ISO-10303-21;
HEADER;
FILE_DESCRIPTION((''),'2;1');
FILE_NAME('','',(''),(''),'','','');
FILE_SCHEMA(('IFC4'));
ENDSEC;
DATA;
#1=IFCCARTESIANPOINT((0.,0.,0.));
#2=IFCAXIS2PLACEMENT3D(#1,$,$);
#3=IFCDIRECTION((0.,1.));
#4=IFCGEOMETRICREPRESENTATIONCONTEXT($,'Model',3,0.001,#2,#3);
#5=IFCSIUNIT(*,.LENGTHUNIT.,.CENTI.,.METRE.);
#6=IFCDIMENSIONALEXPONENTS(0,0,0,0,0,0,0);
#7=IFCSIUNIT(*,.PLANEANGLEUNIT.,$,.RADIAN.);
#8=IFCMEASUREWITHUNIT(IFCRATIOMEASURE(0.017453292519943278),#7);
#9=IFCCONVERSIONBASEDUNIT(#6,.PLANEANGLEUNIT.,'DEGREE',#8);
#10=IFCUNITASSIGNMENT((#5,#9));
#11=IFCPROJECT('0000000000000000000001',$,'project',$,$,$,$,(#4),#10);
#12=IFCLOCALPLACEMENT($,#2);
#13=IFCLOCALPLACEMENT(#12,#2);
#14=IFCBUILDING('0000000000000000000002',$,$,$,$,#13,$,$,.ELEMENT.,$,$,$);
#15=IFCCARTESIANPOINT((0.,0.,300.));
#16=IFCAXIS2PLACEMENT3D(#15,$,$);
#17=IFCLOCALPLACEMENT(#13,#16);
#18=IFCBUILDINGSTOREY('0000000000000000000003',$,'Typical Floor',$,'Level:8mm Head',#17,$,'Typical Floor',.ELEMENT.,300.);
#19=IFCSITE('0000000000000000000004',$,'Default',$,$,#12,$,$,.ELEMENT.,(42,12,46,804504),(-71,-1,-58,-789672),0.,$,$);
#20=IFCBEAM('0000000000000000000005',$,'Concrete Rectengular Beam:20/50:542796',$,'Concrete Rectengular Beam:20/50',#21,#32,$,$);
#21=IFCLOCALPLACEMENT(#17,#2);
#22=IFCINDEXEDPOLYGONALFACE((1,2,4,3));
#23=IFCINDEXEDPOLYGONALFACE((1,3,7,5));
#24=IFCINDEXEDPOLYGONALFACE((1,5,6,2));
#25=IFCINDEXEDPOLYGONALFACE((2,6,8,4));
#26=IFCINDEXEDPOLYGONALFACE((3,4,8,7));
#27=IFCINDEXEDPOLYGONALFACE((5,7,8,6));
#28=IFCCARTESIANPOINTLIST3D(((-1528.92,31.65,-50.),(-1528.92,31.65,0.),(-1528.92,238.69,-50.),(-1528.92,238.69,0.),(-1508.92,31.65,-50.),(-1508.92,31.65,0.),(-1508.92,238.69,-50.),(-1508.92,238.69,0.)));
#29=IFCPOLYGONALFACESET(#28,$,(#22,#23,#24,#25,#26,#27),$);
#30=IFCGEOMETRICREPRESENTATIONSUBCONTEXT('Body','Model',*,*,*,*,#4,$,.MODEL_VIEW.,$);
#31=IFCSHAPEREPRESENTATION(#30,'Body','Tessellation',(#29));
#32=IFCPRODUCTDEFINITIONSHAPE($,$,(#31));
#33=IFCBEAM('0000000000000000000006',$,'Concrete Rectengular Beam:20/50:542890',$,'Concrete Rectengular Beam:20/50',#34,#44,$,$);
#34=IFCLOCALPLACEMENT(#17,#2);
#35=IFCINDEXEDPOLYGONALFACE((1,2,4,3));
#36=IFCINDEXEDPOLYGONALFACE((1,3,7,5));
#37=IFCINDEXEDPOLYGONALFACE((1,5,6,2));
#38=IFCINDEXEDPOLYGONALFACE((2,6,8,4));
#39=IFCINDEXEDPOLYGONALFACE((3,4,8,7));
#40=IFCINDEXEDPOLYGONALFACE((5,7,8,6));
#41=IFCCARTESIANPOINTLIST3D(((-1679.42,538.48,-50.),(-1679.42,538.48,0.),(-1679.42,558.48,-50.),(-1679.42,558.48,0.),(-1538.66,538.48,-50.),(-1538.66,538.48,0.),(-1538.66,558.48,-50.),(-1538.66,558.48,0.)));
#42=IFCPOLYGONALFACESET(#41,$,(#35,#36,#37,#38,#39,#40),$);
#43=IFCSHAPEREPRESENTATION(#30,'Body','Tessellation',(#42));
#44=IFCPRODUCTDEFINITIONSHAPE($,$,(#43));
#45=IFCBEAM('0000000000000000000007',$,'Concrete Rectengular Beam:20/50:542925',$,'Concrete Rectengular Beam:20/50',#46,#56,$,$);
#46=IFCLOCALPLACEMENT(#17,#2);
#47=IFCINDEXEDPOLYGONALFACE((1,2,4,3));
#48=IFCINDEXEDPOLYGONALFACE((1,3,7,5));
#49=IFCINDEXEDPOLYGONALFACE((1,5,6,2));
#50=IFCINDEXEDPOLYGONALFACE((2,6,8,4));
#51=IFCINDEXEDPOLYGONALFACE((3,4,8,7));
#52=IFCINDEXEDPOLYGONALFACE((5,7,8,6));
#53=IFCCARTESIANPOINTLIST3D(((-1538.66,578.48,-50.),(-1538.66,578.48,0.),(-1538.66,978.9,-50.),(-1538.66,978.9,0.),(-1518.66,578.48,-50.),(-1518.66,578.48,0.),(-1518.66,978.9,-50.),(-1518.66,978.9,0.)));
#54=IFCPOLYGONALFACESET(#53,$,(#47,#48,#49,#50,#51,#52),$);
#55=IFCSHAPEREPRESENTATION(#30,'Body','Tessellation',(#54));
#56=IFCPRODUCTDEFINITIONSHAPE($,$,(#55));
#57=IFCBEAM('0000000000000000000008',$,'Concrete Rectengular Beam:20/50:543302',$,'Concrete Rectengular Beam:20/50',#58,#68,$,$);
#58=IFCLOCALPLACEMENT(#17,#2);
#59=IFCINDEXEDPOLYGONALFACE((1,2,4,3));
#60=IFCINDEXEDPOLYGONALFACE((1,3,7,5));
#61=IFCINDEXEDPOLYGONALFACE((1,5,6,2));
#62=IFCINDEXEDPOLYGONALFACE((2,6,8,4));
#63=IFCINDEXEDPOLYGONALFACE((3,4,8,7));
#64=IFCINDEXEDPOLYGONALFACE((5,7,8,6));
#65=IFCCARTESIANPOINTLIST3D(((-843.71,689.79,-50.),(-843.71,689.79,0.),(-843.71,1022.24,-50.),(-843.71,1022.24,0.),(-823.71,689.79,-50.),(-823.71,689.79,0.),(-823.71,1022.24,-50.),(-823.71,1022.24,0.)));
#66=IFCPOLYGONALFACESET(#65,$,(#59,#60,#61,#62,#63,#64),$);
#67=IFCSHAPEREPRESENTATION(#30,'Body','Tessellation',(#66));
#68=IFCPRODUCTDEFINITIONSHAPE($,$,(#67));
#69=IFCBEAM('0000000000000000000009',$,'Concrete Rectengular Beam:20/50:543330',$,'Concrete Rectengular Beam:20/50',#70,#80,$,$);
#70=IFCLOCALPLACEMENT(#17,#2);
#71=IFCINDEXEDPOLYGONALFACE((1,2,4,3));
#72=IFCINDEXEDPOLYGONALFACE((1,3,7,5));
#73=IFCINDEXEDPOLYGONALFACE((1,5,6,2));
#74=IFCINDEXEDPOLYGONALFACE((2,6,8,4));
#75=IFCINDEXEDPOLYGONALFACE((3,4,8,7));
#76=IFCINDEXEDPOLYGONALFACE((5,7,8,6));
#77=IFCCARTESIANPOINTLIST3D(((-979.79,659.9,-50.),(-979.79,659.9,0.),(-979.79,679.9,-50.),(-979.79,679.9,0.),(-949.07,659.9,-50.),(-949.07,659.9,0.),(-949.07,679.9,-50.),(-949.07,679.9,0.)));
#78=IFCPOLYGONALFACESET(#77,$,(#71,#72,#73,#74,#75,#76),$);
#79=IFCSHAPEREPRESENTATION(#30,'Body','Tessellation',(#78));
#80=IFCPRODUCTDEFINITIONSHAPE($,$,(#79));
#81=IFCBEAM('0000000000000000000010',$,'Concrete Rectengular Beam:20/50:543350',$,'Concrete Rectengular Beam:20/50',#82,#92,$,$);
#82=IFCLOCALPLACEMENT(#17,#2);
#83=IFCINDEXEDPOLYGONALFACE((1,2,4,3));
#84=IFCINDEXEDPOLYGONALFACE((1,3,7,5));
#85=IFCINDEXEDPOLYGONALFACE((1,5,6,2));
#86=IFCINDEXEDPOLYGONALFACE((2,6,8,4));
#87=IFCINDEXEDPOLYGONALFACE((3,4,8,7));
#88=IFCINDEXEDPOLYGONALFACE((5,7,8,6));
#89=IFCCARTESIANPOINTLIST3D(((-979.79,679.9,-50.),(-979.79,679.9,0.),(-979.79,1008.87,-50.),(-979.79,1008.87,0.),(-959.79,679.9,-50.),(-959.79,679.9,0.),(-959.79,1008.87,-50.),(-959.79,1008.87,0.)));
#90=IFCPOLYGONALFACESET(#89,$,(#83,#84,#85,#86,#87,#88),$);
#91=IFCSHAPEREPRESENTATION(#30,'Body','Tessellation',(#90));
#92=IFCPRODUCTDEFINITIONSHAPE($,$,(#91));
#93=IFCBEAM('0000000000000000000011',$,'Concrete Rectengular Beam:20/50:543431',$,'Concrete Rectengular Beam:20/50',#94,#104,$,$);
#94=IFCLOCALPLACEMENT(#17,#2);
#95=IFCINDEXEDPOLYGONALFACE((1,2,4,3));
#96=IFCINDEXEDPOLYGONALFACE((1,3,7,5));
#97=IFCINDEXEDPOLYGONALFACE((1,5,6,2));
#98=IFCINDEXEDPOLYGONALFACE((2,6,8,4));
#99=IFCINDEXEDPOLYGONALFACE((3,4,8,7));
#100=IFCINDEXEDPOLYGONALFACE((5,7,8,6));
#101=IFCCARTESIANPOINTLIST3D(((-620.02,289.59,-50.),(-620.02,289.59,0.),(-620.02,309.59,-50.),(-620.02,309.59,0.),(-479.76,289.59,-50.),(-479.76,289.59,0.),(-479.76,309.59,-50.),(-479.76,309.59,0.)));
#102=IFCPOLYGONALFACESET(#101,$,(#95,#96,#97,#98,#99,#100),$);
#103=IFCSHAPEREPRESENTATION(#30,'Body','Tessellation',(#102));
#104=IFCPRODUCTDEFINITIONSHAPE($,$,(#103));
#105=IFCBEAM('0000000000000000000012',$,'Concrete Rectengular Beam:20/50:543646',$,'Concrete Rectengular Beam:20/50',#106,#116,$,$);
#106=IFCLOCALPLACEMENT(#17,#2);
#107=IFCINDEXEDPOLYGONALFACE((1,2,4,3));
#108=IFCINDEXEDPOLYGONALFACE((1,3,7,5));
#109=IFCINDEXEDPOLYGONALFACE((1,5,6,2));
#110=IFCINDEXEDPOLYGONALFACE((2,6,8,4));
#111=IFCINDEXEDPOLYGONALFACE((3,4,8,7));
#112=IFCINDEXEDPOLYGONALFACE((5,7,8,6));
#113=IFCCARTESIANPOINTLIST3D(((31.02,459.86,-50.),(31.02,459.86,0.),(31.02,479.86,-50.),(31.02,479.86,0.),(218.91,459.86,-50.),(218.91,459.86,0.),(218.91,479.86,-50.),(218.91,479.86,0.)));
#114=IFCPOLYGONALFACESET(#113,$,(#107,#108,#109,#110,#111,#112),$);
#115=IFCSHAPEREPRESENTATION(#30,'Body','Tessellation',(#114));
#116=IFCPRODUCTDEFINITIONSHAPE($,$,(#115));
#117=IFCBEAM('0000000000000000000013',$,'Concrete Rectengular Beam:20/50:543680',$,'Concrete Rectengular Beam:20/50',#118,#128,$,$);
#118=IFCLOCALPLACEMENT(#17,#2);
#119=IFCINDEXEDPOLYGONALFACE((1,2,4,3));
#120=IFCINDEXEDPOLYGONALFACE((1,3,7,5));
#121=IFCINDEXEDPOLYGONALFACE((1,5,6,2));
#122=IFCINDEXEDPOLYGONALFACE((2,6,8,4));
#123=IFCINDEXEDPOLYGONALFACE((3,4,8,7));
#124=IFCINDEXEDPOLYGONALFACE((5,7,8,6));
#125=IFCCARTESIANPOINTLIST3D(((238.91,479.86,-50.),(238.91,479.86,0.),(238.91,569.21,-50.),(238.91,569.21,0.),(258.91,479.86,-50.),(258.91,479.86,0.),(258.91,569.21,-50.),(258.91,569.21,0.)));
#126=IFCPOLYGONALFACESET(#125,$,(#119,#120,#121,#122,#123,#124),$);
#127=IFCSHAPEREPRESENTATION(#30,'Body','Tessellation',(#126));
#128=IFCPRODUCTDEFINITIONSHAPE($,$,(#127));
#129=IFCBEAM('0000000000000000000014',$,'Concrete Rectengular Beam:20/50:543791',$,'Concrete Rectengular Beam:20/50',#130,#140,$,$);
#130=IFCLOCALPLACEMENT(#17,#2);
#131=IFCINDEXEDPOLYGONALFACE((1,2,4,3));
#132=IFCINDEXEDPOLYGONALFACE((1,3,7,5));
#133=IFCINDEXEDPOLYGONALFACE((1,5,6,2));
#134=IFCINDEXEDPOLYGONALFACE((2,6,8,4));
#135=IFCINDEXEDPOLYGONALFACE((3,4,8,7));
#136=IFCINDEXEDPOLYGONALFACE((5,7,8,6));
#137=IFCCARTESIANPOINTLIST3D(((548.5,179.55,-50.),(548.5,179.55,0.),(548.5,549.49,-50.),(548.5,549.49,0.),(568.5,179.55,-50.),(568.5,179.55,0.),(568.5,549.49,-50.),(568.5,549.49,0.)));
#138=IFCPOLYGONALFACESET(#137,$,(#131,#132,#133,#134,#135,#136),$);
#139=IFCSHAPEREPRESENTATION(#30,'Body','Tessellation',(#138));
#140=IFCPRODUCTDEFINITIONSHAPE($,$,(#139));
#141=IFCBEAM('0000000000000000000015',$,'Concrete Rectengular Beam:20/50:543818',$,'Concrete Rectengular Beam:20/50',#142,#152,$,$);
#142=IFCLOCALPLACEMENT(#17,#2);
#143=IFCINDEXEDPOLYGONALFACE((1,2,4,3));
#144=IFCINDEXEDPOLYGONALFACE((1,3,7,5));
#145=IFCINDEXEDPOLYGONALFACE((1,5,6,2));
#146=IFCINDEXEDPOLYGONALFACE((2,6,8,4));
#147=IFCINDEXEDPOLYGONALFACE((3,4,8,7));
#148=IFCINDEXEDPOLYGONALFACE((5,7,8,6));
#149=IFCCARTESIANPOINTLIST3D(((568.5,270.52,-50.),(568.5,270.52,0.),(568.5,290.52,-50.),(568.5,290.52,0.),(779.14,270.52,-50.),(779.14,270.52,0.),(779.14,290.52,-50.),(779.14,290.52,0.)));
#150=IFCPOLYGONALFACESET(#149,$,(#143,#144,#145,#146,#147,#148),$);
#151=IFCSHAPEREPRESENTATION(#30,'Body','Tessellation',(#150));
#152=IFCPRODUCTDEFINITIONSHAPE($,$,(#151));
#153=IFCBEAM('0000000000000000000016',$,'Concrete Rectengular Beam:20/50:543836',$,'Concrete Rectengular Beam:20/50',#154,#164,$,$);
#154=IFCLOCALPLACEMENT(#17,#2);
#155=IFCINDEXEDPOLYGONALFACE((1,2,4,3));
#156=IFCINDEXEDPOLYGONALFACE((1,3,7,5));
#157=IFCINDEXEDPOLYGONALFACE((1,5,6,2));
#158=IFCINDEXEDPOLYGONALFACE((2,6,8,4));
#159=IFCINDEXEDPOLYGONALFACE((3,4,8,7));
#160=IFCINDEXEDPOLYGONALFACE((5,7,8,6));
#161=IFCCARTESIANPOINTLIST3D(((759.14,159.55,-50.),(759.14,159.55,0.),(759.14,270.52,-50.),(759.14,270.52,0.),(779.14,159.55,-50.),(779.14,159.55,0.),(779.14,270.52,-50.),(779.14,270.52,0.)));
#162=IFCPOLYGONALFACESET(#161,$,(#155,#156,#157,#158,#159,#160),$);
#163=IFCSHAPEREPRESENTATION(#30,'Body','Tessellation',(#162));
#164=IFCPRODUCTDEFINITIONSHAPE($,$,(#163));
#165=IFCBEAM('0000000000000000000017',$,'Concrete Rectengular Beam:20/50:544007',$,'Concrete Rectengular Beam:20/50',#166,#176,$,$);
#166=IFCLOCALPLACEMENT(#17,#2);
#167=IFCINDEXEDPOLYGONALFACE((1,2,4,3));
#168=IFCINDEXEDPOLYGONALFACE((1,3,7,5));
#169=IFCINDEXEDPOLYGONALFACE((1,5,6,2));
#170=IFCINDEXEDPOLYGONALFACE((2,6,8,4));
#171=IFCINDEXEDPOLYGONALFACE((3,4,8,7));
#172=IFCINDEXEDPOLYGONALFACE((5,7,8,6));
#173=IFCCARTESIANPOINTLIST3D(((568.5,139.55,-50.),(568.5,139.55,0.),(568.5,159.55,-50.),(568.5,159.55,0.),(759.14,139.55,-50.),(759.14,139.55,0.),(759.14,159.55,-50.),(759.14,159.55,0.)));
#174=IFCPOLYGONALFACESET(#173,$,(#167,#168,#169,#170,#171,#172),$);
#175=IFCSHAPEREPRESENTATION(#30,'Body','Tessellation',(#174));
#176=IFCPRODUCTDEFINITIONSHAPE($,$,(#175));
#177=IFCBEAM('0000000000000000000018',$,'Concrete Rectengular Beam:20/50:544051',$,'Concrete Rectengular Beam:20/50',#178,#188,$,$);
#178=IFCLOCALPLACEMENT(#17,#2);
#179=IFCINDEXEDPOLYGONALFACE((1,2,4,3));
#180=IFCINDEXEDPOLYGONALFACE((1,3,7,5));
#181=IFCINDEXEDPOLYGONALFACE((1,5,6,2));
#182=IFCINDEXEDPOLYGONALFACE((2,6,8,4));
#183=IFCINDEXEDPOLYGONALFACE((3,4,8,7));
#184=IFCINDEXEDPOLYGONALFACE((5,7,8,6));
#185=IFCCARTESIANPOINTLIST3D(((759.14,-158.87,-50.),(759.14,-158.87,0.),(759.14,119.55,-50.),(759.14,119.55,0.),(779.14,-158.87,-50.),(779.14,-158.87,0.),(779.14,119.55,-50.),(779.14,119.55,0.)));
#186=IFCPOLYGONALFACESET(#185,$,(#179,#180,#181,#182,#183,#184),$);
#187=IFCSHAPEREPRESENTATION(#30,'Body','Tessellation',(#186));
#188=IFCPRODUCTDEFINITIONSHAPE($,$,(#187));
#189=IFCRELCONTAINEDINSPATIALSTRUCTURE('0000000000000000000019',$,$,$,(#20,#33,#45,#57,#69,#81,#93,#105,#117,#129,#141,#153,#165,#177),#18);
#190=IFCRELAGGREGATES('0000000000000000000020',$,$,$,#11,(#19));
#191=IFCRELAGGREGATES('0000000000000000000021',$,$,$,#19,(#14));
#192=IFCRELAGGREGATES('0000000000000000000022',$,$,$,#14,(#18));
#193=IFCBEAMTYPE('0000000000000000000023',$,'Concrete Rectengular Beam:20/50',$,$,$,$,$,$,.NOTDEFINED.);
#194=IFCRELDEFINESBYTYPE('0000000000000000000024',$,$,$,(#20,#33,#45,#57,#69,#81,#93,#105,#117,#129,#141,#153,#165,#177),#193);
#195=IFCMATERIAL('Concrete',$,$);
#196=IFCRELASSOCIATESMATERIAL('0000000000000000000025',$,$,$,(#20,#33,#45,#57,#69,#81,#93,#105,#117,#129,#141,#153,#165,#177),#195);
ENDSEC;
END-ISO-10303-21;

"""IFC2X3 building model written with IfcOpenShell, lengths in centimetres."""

from ifc_helpers import new_model, entity, si_unit, converted_unit, direction, frame, frame_2d, origin, origin_2d_with_axis, place, context, subcontext, project, spatial, rectangle, extrude, material, type_object, element, save


model = new_model("IFC2X3")

# Units and contexts
model_context = context("Model", 3, precision=0.001, world=origin(), true_north=direction((0.0, 1.0)))
body_context = subcontext(model_context, "Body", "Model", "MODEL_VIEW")
ifc_project = project(units=[si_unit("LENGTHUNIT", "METRE", prefix="CENTI"), converted_unit("PLANEANGLEUNIT", "DEGREE", entity("IfcRatioMeasure", 0.017453292519943278), si_unit("PLANEANGLEUNIT", "RADIAN"), dimensions=[0, 0, 0, 0, 0, 0, 0])], contexts=[model_context])

# Site, building, storey
site_placement = place(None, origin())
site = spatial("IfcSite", under=ifc_project, at=site_placement, Name="Default", CompositionType="ELEMENT", RefLatitude=(42, 12, 46, 804504), RefLongitude=(-71, -1, -58, -789672), RefElevation=0.0)
building_placement = place(site_placement, origin())
building = spatial("IfcBuilding", under=site, at=building_placement, CompositionType="ELEMENT")
storey_placement = place(building_placement, frame((0.0, 0.0, 300.0)))
storey = spatial("IfcBuildingStorey", under=building, at=storey_placement, Name="Typical Floor", ObjectType="Level:8mm Head", LongName="Typical Floor", CompositionType="ELEMENT", Elevation=300.0)

# Beams
ifc_material = material(Name="Concrete")
beam_type_1 = type_object("IfcBeamType", Name="Concrete Rectengular Beam:20/50", PredefinedType="NOTDEFINED")
beam_1_placement = place(storey_placement, frame((-1518.92, 11.65, 0.0), z_axis=(0.0, 0.0, 1.0), x_axis=(0.0, 1.0, 0.0)))
element("IfcBeam", 1, at=beam_1_placement, inside=storey, type_object=beam_type_1, material=ifc_material, Name="Concrete Rectengular Beam:20/50:542796", ObjectType="Concrete Rectengular Beam:20/50", context=body_context, shape_type="SweptSolid", body=[
    extrude(rectangle(XDim=50.0, YDim=20.0, at=frame_2d((0.0, 0.0), x_axis=(1.0, 0.0))), frame((20.0, 0.0, -25.0), z_axis=(1.0, 0.0, 0.0), x_axis=(0.0, 0.0, -1.0)), (0.0, 0.0, 1.0), 207.05),
])
beam_2_placement = place(storey_placement, frame((-1528.66, 548.48, 0.0), z_axis=(0.0, 0.0, 1.0), x_axis=(-1.0, 0.0, 0.0)))
element("IfcBeam", 2, at=beam_2_placement, inside=storey, type_object=beam_type_1, material=ifc_material, Name="Concrete Rectengular Beam:20/50:542890", ObjectType="Concrete Rectengular Beam:20/50", context=body_context, shape_type="SweptSolid", body=[
    extrude(rectangle(XDim=50.0, YDim=20.0, at=frame_2d((0.0, 0.0), x_axis=(1.0, 0.0))), frame((10.0, 0.0, -25.0), z_axis=(1.0, 0.0, 0.0), x_axis=(0.0, 0.0, -1.0)), (0.0, 0.0, 1.0), 140.77),
])
beam_3_placement = place(storey_placement, frame((-1528.66, 558.48, 0.0), z_axis=(0.0, 0.0, 1.0), x_axis=(0.0, 1.0, 0.0)))
element("IfcBeam", 3, at=beam_3_placement, inside=storey, type_object=beam_type_1, material=ifc_material, Name="Concrete Rectengular Beam:20/50:542925", ObjectType="Concrete Rectengular Beam:20/50", context=body_context, shape_type="SweptSolid", body=[
    extrude(rectangle(XDim=50.0, YDim=20.0, at=frame_2d((0.0, 0.0), x_axis=(1.0, 0.0))), frame((20.0, 0.0, -25.0), z_axis=(1.0, 0.0, 0.0), x_axis=(0.0, 0.0, -1.0)), (0.0, 0.0, 1.0), 400.41),
])
beam_4_placement = place(storey_placement, frame((-833.71, 1042.24, 0.0), z_axis=(0.0, 0.0, 1.0), x_axis=(0.0, -1.0, 0.0)))
element("IfcBeam", 4, at=beam_4_placement, inside=storey, type_object=beam_type_1, material=ifc_material, Name="Concrete Rectengular Beam:20/50:543302", ObjectType="Concrete Rectengular Beam:20/50", context=body_context, shape_type="SweptSolid", body=[
    extrude(rectangle(XDim=50.0, YDim=20.0, at=frame_2d((0.0, 0.0), x_axis=(1.0, 0.0))), frame((20.0, 0.0, -25.0), z_axis=(1.0, 0.0, 0.0), x_axis=(0.0, 0.0, -1.0)), (0.0, 0.0, 1.0), 332.45),
])
beam_5_placement = place(storey_placement, frame((-939.07, 669.9, 0.0), z_axis=(0.0, 0.0, 1.0), x_axis=(-1.0, 0.0, 0.0)))
element("IfcBeam", 5, at=beam_5_placement, inside=storey, type_object=beam_type_1, material=ifc_material, Name="Concrete Rectengular Beam:20/50:543330", ObjectType="Concrete Rectengular Beam:20/50", context=body_context, shape_type="SweptSolid", body=[
    extrude(rectangle(XDim=50.0, YDim=20.0, at=frame_2d((0.0, 0.0), x_axis=(1.0, 0.0))), frame((10.0, 0.0, -25.0), z_axis=(1.0, 0.0, 0.0), x_axis=(0.0, 0.0, -1.0)), (0.0, 0.0, 1.0), 30.73),
])
beam_6_placement = place(storey_placement, frame((-969.79, 669.9, 0.0), z_axis=(0.0, 0.0, 1.0), x_axis=(0.0, 1.0, 0.0)))
element("IfcBeam", 6, at=beam_6_placement, inside=storey, type_object=beam_type_1, material=ifc_material, Name="Concrete Rectengular Beam:20/50:543350", ObjectType="Concrete Rectengular Beam:20/50", context=body_context, shape_type="SweptSolid", body=[
    extrude(rectangle(XDim=50.0, YDim=20.0, at=frame_2d((0.0, 0.0), x_axis=(1.0, 0.0))), frame((10.0, 0.0, -25.0), z_axis=(1.0, 0.0, 0.0), x_axis=(0.0, 0.0, -1.0)), (0.0, 0.0, 1.0), 328.98),
])
beam_7_placement = place(storey_placement, frame((-469.76, 299.59, 0.0), z_axis=(0.0, 0.0, 1.0), x_axis=(-1.0, 0.0, 0.0)))
element("IfcBeam", 7, at=beam_7_placement, inside=storey, type_object=beam_type_1, material=ifc_material, Name="Concrete Rectengular Beam:20/50:543431", ObjectType="Concrete Rectengular Beam:20/50", context=body_context, shape_type="SweptSolid", body=[
    extrude(rectangle(XDim=50.0, YDim=20.0, at=frame_2d((0.0, 0.0), x_axis=(1.0, 0.0))), frame((10.0, 0.0, -25.0), z_axis=(1.0, 0.0, 0.0), x_axis=(0.0, 0.0, -1.0)), (0.0, 0.0, 1.0), 140.25),
])
beam_8_placement = place(storey_placement, frame((11.02, 469.86, 0.0)))
element("IfcBeam", 8, at=beam_8_placement, inside=storey, type_object=beam_type_1, material=ifc_material, Name="Concrete Rectengular Beam:20/50:543646", ObjectType="Concrete Rectengular Beam:20/50", context=body_context, shape_type="SweptSolid", body=[
    extrude(rectangle(XDim=50.0, YDim=20.0, at=frame_2d((0.0, 0.0), x_axis=(1.0, 0.0))), frame((20.0, 0.0, -25.0), z_axis=(1.0, 0.0, 0.0), x_axis=(0.0, 0.0, -1.0)), (0.0, 0.0, 1.0), 187.89),
])
beam_9_placement = place(storey_placement, frame((248.91, 579.21, 0.0), z_axis=(0.0, 0.0, 1.0), x_axis=(0.0, -1.0, 0.0)))
element("IfcBeam", 9, at=beam_9_placement, inside=storey, type_object=beam_type_1, material=ifc_material, Name="Concrete Rectengular Beam:20/50:543680", ObjectType="Concrete Rectengular Beam:20/50", context=body_context, shape_type="SweptSolid", body=[
    extrude(rectangle(XDim=50.0, YDim=20.0, at=frame_2d((0.0, 0.0), x_axis=(1.0, 0.0))), frame((10.0, 0.0, -25.0), z_axis=(1.0, 0.0, 0.0), x_axis=(0.0, 0.0, -1.0)), (0.0, 0.0, 1.0), 89.35),
])
beam_10_placement = place(storey_placement, frame((558.5, 569.49, 0.0), z_axis=(0.0, 0.0, 1.0), x_axis=(0.0, -1.0, 0.0)))
element("IfcBeam", 10, at=beam_10_placement, inside=storey, type_object=beam_type_1, material=ifc_material, Name="Concrete Rectengular Beam:20/50:543791", ObjectType="Concrete Rectengular Beam:20/50", context=body_context, shape_type="SweptSolid", body=[
    extrude(rectangle(XDim=50.0, YDim=20.0, at=frame_2d((0.0, 0.0), x_axis=(1.0, 0.0))), frame((20.0, 0.0, -25.0), z_axis=(1.0, 0.0, 0.0), x_axis=(0.0, 0.0, -1.0)), (0.0, 0.0, 1.0), 369.94),
])
beam_11_placement = place(storey_placement, frame((558.5, 280.52, 0.0)))
element("IfcBeam", 11, at=beam_11_placement, inside=storey, type_object=beam_type_1, material=ifc_material, Name="Concrete Rectengular Beam:20/50:543818", ObjectType="Concrete Rectengular Beam:20/50", context=body_context, shape_type="SweptSolid", body=[
    extrude(rectangle(XDim=50.0, YDim=20.0, at=frame_2d((0.0, 0.0), x_axis=(1.0, 0.0))), frame((10.0, 0.0, -25.0), z_axis=(1.0, 0.0, 0.0), x_axis=(0.0, 0.0, -1.0)), (0.0, 0.0, 1.0), 210.64),
])
beam_12_placement = place(storey_placement, frame((769.14, 280.52, 0.0), z_axis=(0.0, 0.0, 1.0), x_axis=(0.0, -1.0, 0.0)))
element("IfcBeam", 12, at=beam_12_placement, inside=storey, type_object=beam_type_1, material=ifc_material, Name="Concrete Rectengular Beam:20/50:543836", ObjectType="Concrete Rectengular Beam:20/50", context=body_context, shape_type="SweptSolid", body=[
    extrude(rectangle(XDim=50.0, YDim=20.0, at=frame_2d((0.0, 0.0), x_axis=(1.0, 0.0))), frame((10.0, 0.0, -25.0), z_axis=(1.0, 0.0, 0.0), x_axis=(0.0, 0.0, -1.0)), (0.0, 0.0, 1.0), 110.96),
])
beam_13_placement = place(storey_placement, frame((769.14, 149.55, 0.0), z_axis=(0.0, 0.0, 1.0), x_axis=(-1.0, 0.0, 0.0)))
element("IfcBeam", 13, at=beam_13_placement, inside=storey, type_object=beam_type_1, material=ifc_material, Name="Concrete Rectengular Beam:20/50:544007", ObjectType="Concrete Rectengular Beam:20/50", context=body_context, shape_type="SweptSolid", body=[
    extrude(rectangle(XDim=50.0, YDim=20.0, at=frame_2d((0.0, 0.0), x_axis=(1.0, 0.0))), frame((10.0, 0.0, -25.0), z_axis=(1.0, 0.0, 0.0), x_axis=(0.0, 0.0, -1.0)), (0.0, 0.0, 1.0), 190.64),
])
beam_14_placement = place(storey_placement, frame((769.14, 139.55, 0.0), z_axis=(0.0, 0.0, 1.0), x_axis=(0.0, -1.0, 0.0)))
element("IfcBeam", 14, at=beam_14_placement, inside=storey, type_object=beam_type_1, material=ifc_material, Name="Concrete Rectengular Beam:20/50:544051", ObjectType="Concrete Rectengular Beam:20/50", context=body_context, shape_type="SweptSolid", body=[
    extrude(rectangle(XDim=50.0, YDim=20.0, at=origin_2d_with_axis()), frame((20.0, 0.0, -25.0), z_axis=(1.0, 0.0, 0.0), x_axis=(0.0, 0.0, -1.0)), (0.0, 0.0, 1.0), 278.42),
])

save(model, "model.ifc")
